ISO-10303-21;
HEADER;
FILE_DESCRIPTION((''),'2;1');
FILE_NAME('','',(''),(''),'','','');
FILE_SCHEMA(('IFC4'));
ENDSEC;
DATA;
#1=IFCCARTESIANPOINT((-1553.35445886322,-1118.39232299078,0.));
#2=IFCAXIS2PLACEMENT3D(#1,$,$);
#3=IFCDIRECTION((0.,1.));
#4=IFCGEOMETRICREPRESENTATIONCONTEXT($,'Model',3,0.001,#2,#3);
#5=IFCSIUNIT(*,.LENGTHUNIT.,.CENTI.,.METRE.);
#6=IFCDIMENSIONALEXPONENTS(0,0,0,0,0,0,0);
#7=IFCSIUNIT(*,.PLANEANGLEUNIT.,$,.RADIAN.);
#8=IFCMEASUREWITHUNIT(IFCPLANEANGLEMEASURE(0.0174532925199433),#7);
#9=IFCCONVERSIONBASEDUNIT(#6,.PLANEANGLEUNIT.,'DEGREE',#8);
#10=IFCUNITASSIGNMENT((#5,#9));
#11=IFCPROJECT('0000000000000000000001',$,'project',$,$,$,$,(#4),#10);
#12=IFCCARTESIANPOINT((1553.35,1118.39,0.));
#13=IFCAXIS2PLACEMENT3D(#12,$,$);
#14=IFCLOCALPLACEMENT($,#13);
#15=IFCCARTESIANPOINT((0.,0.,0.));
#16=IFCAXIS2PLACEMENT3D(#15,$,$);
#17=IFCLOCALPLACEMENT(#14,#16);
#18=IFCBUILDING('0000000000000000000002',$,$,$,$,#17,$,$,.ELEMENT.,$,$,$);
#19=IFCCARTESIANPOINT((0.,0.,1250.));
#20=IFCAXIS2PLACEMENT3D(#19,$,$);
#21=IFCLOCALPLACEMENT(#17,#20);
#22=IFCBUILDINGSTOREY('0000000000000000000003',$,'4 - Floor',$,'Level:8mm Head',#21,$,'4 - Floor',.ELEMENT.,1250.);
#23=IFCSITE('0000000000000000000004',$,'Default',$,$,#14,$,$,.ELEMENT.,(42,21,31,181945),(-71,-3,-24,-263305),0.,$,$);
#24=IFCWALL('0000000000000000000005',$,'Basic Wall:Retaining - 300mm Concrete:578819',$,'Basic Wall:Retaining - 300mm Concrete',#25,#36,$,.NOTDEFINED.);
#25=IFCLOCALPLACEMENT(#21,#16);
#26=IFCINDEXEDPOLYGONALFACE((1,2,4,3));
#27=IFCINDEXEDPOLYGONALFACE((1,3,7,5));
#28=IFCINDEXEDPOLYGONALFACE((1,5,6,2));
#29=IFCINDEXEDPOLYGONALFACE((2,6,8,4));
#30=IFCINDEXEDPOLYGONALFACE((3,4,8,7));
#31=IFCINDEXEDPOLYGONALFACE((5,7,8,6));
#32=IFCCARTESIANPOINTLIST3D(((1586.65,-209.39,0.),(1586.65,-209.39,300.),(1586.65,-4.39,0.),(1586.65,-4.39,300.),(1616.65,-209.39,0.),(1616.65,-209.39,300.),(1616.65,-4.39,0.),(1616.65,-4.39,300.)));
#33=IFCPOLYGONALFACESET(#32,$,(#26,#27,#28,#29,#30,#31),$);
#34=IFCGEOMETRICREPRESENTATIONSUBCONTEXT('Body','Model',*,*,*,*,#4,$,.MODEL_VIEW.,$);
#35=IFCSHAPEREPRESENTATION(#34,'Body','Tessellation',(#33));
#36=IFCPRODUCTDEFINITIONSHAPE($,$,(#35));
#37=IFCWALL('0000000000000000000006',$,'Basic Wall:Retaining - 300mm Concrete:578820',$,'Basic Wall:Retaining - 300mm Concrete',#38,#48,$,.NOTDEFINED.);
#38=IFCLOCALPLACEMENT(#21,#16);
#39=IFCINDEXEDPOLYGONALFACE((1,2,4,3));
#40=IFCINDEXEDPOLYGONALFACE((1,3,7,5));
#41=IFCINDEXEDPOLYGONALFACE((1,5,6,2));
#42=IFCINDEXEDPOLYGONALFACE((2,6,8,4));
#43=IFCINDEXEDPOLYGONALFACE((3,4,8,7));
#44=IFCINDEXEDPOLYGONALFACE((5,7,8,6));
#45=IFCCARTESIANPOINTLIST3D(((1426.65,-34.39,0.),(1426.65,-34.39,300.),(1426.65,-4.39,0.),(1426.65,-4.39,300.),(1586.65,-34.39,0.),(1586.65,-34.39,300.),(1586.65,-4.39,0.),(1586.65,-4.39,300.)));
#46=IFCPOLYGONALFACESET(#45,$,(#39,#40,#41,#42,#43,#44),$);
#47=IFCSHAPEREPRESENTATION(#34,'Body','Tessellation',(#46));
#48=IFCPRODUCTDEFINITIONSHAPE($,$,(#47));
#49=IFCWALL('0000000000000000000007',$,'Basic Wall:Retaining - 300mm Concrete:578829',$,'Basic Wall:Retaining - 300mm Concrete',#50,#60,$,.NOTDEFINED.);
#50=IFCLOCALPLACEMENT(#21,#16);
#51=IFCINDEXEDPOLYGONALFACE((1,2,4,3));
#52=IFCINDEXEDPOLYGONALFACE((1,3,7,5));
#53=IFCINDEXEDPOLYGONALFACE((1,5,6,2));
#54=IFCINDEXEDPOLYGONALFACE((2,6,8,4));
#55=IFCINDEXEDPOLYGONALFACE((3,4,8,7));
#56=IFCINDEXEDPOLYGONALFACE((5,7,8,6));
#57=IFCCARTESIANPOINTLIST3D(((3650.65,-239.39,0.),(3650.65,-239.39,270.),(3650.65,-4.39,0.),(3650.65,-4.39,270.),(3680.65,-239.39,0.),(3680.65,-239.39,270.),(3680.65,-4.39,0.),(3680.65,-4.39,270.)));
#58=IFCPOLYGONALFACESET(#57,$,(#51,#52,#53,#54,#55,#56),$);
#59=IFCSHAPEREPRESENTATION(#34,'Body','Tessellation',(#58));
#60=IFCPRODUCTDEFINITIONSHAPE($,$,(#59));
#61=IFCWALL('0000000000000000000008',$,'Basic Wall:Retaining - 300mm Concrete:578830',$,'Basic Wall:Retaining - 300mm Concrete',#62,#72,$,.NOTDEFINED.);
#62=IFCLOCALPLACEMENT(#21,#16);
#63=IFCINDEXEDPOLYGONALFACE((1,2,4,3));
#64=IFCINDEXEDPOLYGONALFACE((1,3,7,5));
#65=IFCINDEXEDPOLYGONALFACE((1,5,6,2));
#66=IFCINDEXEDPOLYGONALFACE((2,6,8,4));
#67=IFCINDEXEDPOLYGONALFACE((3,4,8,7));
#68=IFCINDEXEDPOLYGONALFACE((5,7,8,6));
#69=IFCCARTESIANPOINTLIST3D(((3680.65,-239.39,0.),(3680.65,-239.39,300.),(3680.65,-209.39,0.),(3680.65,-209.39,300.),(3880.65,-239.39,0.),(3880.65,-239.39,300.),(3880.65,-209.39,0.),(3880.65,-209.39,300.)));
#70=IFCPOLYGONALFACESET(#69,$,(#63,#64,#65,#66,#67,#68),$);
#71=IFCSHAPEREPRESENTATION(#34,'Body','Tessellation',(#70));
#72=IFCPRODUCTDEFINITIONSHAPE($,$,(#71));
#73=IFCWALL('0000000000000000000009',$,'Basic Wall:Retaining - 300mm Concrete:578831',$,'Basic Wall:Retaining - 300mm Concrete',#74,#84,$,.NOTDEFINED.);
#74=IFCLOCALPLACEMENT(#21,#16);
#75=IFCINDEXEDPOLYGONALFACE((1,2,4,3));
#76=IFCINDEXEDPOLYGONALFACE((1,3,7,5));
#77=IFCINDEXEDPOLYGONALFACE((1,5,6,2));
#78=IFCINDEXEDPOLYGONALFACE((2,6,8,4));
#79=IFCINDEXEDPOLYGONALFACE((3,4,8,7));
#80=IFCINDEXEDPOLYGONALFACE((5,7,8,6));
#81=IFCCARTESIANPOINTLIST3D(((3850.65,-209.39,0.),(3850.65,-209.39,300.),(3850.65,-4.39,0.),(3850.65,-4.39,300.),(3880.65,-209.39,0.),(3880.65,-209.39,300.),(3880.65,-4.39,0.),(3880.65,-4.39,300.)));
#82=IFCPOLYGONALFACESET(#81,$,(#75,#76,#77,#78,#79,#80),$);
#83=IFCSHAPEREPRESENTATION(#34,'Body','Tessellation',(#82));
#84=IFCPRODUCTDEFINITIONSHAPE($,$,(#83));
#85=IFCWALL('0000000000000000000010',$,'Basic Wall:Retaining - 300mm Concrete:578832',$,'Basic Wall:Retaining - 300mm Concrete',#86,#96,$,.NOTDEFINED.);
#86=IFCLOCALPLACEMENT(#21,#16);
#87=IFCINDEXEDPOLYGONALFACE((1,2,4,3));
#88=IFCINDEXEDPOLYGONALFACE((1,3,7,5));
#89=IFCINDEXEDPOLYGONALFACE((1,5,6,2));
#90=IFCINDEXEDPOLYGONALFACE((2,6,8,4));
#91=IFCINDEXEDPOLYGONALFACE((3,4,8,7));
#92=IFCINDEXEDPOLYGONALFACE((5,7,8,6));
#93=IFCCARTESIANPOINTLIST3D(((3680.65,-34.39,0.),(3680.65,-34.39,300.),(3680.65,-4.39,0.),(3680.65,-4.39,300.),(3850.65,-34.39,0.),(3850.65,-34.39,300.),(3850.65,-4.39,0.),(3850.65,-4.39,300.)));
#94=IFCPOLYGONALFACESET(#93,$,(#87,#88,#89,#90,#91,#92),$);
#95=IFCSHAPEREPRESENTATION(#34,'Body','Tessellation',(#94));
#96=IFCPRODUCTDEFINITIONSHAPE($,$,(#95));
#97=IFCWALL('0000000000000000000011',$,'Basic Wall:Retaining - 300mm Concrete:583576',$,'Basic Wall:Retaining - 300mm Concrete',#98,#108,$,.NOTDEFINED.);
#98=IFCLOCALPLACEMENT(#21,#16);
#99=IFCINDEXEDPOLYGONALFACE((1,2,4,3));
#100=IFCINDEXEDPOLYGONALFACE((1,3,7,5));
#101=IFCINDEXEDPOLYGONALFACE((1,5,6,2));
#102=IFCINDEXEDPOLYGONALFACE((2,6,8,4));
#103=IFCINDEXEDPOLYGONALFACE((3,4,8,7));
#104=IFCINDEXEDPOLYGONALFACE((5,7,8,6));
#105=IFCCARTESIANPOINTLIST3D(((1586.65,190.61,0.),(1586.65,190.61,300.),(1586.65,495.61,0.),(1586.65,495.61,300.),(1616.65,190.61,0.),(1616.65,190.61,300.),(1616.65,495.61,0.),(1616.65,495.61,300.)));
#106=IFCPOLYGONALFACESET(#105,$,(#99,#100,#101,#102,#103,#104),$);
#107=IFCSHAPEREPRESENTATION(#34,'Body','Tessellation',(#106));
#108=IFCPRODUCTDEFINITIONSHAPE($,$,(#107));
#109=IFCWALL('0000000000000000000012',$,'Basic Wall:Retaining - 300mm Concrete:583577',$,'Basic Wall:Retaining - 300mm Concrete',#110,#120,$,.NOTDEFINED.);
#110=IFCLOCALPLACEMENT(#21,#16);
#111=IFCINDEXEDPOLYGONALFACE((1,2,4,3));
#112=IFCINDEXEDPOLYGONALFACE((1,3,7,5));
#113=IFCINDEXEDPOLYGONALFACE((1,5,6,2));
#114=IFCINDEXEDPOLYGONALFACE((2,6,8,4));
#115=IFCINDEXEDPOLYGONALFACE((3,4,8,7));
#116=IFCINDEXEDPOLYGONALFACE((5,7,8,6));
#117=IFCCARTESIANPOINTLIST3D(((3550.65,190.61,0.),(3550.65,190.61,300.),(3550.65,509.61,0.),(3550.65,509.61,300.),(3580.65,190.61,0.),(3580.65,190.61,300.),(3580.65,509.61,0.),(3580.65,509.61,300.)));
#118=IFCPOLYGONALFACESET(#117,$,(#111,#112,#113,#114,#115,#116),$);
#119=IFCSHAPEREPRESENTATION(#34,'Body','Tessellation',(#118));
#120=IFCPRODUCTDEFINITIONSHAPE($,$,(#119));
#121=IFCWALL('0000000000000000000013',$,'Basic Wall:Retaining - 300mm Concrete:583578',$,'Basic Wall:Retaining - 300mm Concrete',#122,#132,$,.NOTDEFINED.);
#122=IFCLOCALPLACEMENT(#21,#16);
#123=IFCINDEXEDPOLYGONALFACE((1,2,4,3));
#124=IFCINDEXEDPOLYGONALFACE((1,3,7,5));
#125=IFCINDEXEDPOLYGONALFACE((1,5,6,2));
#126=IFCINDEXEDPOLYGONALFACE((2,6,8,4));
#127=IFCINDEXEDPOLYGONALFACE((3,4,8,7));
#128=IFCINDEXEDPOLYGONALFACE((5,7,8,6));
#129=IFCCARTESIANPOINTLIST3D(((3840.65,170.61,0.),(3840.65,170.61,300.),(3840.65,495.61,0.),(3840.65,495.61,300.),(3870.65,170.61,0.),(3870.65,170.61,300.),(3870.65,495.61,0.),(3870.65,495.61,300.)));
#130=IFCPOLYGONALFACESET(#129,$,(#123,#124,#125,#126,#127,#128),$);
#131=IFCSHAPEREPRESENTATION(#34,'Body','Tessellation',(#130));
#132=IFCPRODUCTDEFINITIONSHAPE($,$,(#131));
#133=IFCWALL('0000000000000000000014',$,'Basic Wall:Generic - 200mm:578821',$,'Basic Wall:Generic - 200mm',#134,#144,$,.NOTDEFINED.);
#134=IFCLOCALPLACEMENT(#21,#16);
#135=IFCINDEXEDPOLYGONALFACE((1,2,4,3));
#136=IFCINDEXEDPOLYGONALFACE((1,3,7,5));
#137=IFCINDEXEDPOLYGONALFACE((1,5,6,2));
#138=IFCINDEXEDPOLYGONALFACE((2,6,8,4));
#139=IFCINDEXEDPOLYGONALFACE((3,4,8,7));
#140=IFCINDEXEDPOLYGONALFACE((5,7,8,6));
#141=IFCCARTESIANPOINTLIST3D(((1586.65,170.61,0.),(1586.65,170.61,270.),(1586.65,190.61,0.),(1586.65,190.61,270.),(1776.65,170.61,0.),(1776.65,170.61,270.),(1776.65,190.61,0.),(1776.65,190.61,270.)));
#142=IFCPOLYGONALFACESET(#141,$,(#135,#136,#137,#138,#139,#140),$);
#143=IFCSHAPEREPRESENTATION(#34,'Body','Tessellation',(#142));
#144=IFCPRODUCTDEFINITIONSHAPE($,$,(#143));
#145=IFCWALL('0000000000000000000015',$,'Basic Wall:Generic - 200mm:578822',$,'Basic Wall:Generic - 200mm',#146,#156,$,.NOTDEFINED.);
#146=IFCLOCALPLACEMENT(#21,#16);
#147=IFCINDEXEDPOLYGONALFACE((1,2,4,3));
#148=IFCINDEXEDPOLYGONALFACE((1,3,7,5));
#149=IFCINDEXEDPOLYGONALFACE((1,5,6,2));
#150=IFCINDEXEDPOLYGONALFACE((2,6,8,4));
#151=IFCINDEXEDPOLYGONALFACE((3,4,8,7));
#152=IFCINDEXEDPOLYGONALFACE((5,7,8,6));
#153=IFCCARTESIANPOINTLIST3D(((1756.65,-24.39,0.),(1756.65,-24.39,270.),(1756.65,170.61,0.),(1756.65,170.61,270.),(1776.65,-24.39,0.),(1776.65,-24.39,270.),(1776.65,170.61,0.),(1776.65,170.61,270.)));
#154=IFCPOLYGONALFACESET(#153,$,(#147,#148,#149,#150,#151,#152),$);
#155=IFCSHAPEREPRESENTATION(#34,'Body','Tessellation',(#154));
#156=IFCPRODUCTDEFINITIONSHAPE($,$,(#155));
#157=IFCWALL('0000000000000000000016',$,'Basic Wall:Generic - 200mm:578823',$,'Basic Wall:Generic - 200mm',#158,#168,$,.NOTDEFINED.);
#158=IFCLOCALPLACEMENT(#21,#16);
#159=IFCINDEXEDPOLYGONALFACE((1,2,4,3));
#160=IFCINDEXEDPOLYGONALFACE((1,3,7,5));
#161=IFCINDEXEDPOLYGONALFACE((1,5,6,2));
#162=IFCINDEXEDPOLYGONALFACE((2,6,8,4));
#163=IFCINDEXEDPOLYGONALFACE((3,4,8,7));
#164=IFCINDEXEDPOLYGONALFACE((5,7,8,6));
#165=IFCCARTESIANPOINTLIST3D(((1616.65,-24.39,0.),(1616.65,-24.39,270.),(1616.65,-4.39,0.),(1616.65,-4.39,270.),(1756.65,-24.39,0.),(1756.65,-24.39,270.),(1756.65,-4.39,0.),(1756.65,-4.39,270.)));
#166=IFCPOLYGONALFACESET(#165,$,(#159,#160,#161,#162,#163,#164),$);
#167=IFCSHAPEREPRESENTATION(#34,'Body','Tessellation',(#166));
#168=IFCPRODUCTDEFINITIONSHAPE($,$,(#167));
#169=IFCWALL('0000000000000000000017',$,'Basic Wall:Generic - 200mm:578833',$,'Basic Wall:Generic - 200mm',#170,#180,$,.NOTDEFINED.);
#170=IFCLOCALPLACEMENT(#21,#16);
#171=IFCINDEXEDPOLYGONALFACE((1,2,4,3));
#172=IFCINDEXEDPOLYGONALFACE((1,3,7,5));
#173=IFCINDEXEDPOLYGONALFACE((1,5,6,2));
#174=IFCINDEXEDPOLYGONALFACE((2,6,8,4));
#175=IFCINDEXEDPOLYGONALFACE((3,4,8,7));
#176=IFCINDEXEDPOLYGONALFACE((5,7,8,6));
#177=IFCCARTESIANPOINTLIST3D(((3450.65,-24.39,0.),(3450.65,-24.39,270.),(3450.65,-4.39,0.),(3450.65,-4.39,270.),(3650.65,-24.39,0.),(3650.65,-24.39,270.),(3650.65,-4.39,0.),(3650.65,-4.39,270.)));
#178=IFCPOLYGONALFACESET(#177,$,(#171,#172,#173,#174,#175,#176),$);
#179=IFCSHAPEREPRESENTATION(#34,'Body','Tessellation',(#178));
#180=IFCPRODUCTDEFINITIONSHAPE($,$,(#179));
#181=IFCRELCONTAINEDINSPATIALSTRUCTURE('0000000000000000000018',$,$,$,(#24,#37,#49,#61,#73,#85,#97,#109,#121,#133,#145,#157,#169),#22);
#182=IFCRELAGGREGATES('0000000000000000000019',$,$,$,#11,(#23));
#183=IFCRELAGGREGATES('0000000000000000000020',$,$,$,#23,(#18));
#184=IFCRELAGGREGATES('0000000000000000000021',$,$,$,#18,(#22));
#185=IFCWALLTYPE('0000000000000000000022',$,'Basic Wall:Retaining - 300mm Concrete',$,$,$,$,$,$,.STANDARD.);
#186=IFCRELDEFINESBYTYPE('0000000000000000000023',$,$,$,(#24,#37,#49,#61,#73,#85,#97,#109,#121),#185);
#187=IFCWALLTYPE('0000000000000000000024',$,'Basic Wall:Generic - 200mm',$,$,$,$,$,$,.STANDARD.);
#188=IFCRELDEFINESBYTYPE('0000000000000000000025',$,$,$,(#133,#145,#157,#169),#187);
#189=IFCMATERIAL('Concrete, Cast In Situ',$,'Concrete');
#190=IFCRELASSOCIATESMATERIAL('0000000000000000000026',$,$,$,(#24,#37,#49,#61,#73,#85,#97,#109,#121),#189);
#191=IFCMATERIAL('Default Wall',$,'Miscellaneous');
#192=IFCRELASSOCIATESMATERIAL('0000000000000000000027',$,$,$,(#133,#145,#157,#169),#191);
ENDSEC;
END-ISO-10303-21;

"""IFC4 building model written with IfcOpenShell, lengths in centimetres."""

from ifc_helpers import new_model, entity, si_unit, converted_unit, direction, frame, origin, place, context, subcontext, project, spatial, indexed_curve, outline, extrude, material, type_object, element, save


model = new_model("IFC4")

# Units and contexts
model_context = context("Model", 3, precision=0.001, world=frame((-1553.35445886322, -1118.39232299078, 0.0)), true_north=direction((0.0, 1.0)))
body_context = subcontext(model_context, "Body", "Model", "MODEL_VIEW")
ifc_project = project(units=[si_unit("LENGTHUNIT", "METRE", prefix="CENTI"), converted_unit("PLANEANGLEUNIT", "DEGREE", entity("IfcPlaneAngleMeasure", 0.0174532925199433), si_unit("PLANEANGLEUNIT", "RADIAN"), dimensions=[0, 0, 0, 0, 0, 0, 0])], contexts=[model_context])

# Site, building, storey
site_placement = place(None, frame((1553.35, 1118.39, 0.0)))
site = spatial("IfcSite", under=ifc_project, at=site_placement, Name="Default", CompositionType="ELEMENT", RefLatitude=(42, 21, 31, 181945), RefLongitude=(-71, -3, -24, -263305), RefElevation=0.0)
building_placement = place(site_placement, origin())
building = spatial("IfcBuilding", under=site, at=building_placement, CompositionType="ELEMENT")
storey_placement = place(building_placement, frame((0.0, 0.0, 1250.0)))
storey = spatial("IfcBuildingStorey", under=building, at=storey_placement, Name="4 - Floor", ObjectType="Level:8mm Head", LongName="4 - Floor", CompositionType="ELEMENT", Elevation=1250.0)

# Walls
ifc_material_1 = material(Name="Concrete, Cast In Situ", Category="Concrete")
wall_type_1 = type_object("IfcWallType", Name="Basic Wall:Retaining - 300mm Concrete", PredefinedType="STANDARD")
wall_1_placement = place(storey_placement, frame((1601.65, -209.39, 0.0), z_axis=(0.0, 0.0, 1.0), x_axis=(0.0, 1.0, 0.0)))
element("IfcWall", 1, at=wall_1_placement, inside=storey, type_object=wall_type_1, material=ifc_material_1, Name="Basic Wall:Retaining - 300mm Concrete:578819", ObjectType="Basic Wall:Retaining - 300mm Concrete", PredefinedType="NOTDEFINED", context=body_context, shape_type="SweptSolid", body=[
    extrude(outline(indexed_curve([(205.0, 15.0), (0.0, 15.0), (0.0, -15.0), (205.0, -15.0), (205.0, 15.0)], self_intersect=False)), origin(), (0.0, 0.0, 1.0), 300.0),
])
wall_2_placement = place(storey_placement, frame((1586.65, -19.39, 0.0), z_axis=(0.0, 0.0, 1.0), x_axis=(-1.0, 0.0, 0.0)))
element("IfcWall", 2, at=wall_2_placement, inside=storey, type_object=wall_type_1, material=ifc_material_1, Name="Basic Wall:Retaining - 300mm Concrete:578820", ObjectType="Basic Wall:Retaining - 300mm Concrete", PredefinedType="NOTDEFINED", context=body_context, shape_type="SweptSolid", body=[
    extrude(outline(indexed_curve([(160.0, 15.0), (0.0, 15.0), (0.0, -15.0), (160.0, -15.0), (160.0, 15.0)], self_intersect=False)), origin(), (0.0, 0.0, 1.0), 300.0),
])
wall_3_placement = place(storey_placement, frame((3665.65, -4.39, 0.0), z_axis=(0.0, 0.0, 1.0), x_axis=(0.0, -1.0, 0.0)))
element("IfcWall", 3, at=wall_3_placement, inside=storey, type_object=wall_type_1, material=ifc_material_1, Name="Basic Wall:Retaining - 300mm Concrete:578829", ObjectType="Basic Wall:Retaining - 300mm Concrete", PredefinedType="NOTDEFINED", context=body_context, shape_type="SweptSolid", body=[
    extrude(outline(indexed_curve([(235.0, 15.0), (0.0, 15.0), (0.0, -15.0), (235.0, -15.0), (235.0, 15.0)], self_intersect=False)), origin(), (0.0, 0.0, 1.0), 270.0),
])
wall_4_placement = place(storey_placement, frame((3680.65, -224.39, 0.0)))
element("IfcWall", 4, at=wall_4_placement, inside=storey, type_object=wall_type_1, material=ifc_material_1, Name="Basic Wall:Retaining - 300mm Concrete:578830", ObjectType="Basic Wall:Retaining - 300mm Concrete", PredefinedType="NOTDEFINED", context=body_context, shape_type="SweptSolid", body=[
    extrude(outline(indexed_curve([(200.0, 15.0), (0.0, 15.0), (0.0, -15.0), (200.0, -15.0), (200.0, 15.0)], self_intersect=False)), origin(), (0.0, 0.0, 1.0), 300.0),
])
wall_5_placement = place(storey_placement, frame((3865.65, -209.39, 0.0), z_axis=(0.0, 0.0, 1.0), x_axis=(0.0, 1.0, 0.0)))
element("IfcWall", 5, at=wall_5_placement, inside=storey, type_object=wall_type_1, material=ifc_material_1, Name="Basic Wall:Retaining - 300mm Concrete:578831", ObjectType="Basic Wall:Retaining - 300mm Concrete", PredefinedType="NOTDEFINED", context=body_context, shape_type="SweptSolid", body=[
    extrude(outline(indexed_curve([(205.0, 15.0), (0.0, 15.0), (0.0, -15.0), (205.0, -15.0), (205.0, 15.0)], self_intersect=False)), origin(), (0.0, 0.0, 1.0), 300.0),
])
wall_6_placement = place(storey_placement, frame((3850.65, -19.39, 0.0), z_axis=(0.0, 0.0, 1.0), x_axis=(-1.0, 0.0, 0.0)))
element("IfcWall", 6, at=wall_6_placement, inside=storey, type_object=wall_type_1, material=ifc_material_1, Name="Basic Wall:Retaining - 300mm Concrete:578832", ObjectType="Basic Wall:Retaining - 300mm Concrete", PredefinedType="NOTDEFINED", context=body_context, shape_type="SweptSolid", body=[
    extrude(outline(indexed_curve([(170.0, 15.0), (0.0, 15.0), (0.0, -15.0), (170.0, -15.0), (170.0, 15.0)], self_intersect=False)), origin(), (0.0, 0.0, 1.0), 300.0),
])
wall_7_placement = place(storey_placement, frame((1601.65, 495.61, 0.0), z_axis=(0.0, 0.0, 1.0), x_axis=(0.0, -1.0, 0.0)))
element("IfcWall", 7, at=wall_7_placement, inside=storey, type_object=wall_type_1, material=ifc_material_1, Name="Basic Wall:Retaining - 300mm Concrete:583576", ObjectType="Basic Wall:Retaining - 300mm Concrete", PredefinedType="NOTDEFINED", context=body_context, shape_type="SweptSolid", body=[
    extrude(outline(indexed_curve([(305.0, 15.0), (0.0, 15.0), (0.0, -15.0), (305.0, -15.0), (305.0, 15.0)], self_intersect=False)), origin(), (0.0, 0.0, 1.0), 300.0),
])
wall_8_placement = place(storey_placement, frame((3565.65, 509.61, 0.0), z_axis=(0.0, 0.0, 1.0), x_axis=(0.0, -1.0, 0.0)))
element("IfcWall", 8, at=wall_8_placement, inside=storey, type_object=wall_type_1, material=ifc_material_1, Name="Basic Wall:Retaining - 300mm Concrete:583577", ObjectType="Basic Wall:Retaining - 300mm Concrete", PredefinedType="NOTDEFINED", context=body_context, shape_type="SweptSolid", body=[
    extrude(outline(indexed_curve([(319.0, 15.0), (0.0, 15.0), (0.0, -15.0), (319.0, -15.0), (319.0, 15.0)], self_intersect=False)), origin(), (0.0, 0.0, 1.0), 300.0),
])
wall_9_placement = place(storey_placement, frame((3855.65, 495.61, 0.0), z_axis=(0.0, 0.0, 1.0), x_axis=(0.0, -1.0, 0.0)))
element("IfcWall", 9, at=wall_9_placement, inside=storey, type_object=wall_type_1, material=ifc_material_1, Name="Basic Wall:Retaining - 300mm Concrete:583578", ObjectType="Basic Wall:Retaining - 300mm Concrete", PredefinedType="NOTDEFINED", context=body_context, shape_type="SweptSolid", body=[
    extrude(outline(indexed_curve([(325.0, 15.0), (0.0, 15.0), (0.0, -15.0), (325.0, -15.0), (325.0, 15.0)], self_intersect=False)), origin(), (0.0, 0.0, 1.0), 300.0),
])
ifc_material_2 = material(Name="Default Wall", Category="Miscellaneous")
wall_type_2 = type_object("IfcWallType", Name="Basic Wall:Generic - 200mm", PredefinedType="STANDARD")
wall_10_placement = place(storey_placement, frame((1586.65, 180.61, 0.0)))
element("IfcWall", 10, at=wall_10_placement, inside=storey, type_object=wall_type_2, material=ifc_material_2, Name="Basic Wall:Generic - 200mm:578821", ObjectType="Basic Wall:Generic - 200mm", PredefinedType="NOTDEFINED", context=body_context, shape_type="SweptSolid", body=[
    extrude(outline(indexed_curve([(190.0, 10.0), (0.0, 10.0), (0.0, -10.0), (190.0, -10.0), (190.0, 10.0)], self_intersect=False)), origin(), (0.0, 0.0, 1.0), 270.0),
])
wall_11_placement = place(storey_placement, frame((1766.65, 170.61, 0.0), z_axis=(0.0, 0.0, 1.0), x_axis=(0.0, -1.0, 0.0)))
element("IfcWall", 11, at=wall_11_placement, inside=storey, type_object=wall_type_2, material=ifc_material_2, Name="Basic Wall:Generic - 200mm:578822", ObjectType="Basic Wall:Generic - 200mm", PredefinedType="NOTDEFINED", context=body_context, shape_type="SweptSolid", body=[
    extrude(outline(indexed_curve([(195.0, 10.0), (0.0, 10.0), (0.0, -10.0), (195.0, -10.0), (195.0, 10.0)], self_intersect=False)), origin(), (0.0, 0.0, 1.0), 270.0),
])
wall_12_placement = place(storey_placement, frame((1616.65, -14.39, 0.0)))
element("IfcWall", 12, at=wall_12_placement, inside=storey, type_object=wall_type_2, material=ifc_material_2, Name="Basic Wall:Generic - 200mm:578823", ObjectType="Basic Wall:Generic - 200mm", PredefinedType="NOTDEFINED", context=body_context, shape_type="SweptSolid", body=[
    extrude(outline(indexed_curve([(140.0, 10.0), (0.0, 10.0), (0.0, -10.0), (140.0, -10.0), (140.0, 10.0)], self_intersect=False)), origin(), (0.0, 0.0, 1.0), 270.0),
])
wall_13_placement = place(storey_placement, frame((3650.65, -14.39, 0.0), z_axis=(0.0, 0.0, 1.0), x_axis=(-1.0, 0.0, 0.0)))
element("IfcWall", 13, at=wall_13_placement, inside=storey, type_object=wall_type_2, material=ifc_material_2, Name="Basic Wall:Generic - 200mm:578833", ObjectType="Basic Wall:Generic - 200mm", PredefinedType="NOTDEFINED", context=body_context, shape_type="SweptSolid", body=[
    extrude(outline(indexed_curve([(200.0, 10.0), (0.0, 10.0), (0.0, -10.0), (200.0, -10.0), (200.0, 10.0)], self_intersect=False)), origin(), (0.0, 0.0, 1.0), 270.0),
])

save(model, "model.ifc")
